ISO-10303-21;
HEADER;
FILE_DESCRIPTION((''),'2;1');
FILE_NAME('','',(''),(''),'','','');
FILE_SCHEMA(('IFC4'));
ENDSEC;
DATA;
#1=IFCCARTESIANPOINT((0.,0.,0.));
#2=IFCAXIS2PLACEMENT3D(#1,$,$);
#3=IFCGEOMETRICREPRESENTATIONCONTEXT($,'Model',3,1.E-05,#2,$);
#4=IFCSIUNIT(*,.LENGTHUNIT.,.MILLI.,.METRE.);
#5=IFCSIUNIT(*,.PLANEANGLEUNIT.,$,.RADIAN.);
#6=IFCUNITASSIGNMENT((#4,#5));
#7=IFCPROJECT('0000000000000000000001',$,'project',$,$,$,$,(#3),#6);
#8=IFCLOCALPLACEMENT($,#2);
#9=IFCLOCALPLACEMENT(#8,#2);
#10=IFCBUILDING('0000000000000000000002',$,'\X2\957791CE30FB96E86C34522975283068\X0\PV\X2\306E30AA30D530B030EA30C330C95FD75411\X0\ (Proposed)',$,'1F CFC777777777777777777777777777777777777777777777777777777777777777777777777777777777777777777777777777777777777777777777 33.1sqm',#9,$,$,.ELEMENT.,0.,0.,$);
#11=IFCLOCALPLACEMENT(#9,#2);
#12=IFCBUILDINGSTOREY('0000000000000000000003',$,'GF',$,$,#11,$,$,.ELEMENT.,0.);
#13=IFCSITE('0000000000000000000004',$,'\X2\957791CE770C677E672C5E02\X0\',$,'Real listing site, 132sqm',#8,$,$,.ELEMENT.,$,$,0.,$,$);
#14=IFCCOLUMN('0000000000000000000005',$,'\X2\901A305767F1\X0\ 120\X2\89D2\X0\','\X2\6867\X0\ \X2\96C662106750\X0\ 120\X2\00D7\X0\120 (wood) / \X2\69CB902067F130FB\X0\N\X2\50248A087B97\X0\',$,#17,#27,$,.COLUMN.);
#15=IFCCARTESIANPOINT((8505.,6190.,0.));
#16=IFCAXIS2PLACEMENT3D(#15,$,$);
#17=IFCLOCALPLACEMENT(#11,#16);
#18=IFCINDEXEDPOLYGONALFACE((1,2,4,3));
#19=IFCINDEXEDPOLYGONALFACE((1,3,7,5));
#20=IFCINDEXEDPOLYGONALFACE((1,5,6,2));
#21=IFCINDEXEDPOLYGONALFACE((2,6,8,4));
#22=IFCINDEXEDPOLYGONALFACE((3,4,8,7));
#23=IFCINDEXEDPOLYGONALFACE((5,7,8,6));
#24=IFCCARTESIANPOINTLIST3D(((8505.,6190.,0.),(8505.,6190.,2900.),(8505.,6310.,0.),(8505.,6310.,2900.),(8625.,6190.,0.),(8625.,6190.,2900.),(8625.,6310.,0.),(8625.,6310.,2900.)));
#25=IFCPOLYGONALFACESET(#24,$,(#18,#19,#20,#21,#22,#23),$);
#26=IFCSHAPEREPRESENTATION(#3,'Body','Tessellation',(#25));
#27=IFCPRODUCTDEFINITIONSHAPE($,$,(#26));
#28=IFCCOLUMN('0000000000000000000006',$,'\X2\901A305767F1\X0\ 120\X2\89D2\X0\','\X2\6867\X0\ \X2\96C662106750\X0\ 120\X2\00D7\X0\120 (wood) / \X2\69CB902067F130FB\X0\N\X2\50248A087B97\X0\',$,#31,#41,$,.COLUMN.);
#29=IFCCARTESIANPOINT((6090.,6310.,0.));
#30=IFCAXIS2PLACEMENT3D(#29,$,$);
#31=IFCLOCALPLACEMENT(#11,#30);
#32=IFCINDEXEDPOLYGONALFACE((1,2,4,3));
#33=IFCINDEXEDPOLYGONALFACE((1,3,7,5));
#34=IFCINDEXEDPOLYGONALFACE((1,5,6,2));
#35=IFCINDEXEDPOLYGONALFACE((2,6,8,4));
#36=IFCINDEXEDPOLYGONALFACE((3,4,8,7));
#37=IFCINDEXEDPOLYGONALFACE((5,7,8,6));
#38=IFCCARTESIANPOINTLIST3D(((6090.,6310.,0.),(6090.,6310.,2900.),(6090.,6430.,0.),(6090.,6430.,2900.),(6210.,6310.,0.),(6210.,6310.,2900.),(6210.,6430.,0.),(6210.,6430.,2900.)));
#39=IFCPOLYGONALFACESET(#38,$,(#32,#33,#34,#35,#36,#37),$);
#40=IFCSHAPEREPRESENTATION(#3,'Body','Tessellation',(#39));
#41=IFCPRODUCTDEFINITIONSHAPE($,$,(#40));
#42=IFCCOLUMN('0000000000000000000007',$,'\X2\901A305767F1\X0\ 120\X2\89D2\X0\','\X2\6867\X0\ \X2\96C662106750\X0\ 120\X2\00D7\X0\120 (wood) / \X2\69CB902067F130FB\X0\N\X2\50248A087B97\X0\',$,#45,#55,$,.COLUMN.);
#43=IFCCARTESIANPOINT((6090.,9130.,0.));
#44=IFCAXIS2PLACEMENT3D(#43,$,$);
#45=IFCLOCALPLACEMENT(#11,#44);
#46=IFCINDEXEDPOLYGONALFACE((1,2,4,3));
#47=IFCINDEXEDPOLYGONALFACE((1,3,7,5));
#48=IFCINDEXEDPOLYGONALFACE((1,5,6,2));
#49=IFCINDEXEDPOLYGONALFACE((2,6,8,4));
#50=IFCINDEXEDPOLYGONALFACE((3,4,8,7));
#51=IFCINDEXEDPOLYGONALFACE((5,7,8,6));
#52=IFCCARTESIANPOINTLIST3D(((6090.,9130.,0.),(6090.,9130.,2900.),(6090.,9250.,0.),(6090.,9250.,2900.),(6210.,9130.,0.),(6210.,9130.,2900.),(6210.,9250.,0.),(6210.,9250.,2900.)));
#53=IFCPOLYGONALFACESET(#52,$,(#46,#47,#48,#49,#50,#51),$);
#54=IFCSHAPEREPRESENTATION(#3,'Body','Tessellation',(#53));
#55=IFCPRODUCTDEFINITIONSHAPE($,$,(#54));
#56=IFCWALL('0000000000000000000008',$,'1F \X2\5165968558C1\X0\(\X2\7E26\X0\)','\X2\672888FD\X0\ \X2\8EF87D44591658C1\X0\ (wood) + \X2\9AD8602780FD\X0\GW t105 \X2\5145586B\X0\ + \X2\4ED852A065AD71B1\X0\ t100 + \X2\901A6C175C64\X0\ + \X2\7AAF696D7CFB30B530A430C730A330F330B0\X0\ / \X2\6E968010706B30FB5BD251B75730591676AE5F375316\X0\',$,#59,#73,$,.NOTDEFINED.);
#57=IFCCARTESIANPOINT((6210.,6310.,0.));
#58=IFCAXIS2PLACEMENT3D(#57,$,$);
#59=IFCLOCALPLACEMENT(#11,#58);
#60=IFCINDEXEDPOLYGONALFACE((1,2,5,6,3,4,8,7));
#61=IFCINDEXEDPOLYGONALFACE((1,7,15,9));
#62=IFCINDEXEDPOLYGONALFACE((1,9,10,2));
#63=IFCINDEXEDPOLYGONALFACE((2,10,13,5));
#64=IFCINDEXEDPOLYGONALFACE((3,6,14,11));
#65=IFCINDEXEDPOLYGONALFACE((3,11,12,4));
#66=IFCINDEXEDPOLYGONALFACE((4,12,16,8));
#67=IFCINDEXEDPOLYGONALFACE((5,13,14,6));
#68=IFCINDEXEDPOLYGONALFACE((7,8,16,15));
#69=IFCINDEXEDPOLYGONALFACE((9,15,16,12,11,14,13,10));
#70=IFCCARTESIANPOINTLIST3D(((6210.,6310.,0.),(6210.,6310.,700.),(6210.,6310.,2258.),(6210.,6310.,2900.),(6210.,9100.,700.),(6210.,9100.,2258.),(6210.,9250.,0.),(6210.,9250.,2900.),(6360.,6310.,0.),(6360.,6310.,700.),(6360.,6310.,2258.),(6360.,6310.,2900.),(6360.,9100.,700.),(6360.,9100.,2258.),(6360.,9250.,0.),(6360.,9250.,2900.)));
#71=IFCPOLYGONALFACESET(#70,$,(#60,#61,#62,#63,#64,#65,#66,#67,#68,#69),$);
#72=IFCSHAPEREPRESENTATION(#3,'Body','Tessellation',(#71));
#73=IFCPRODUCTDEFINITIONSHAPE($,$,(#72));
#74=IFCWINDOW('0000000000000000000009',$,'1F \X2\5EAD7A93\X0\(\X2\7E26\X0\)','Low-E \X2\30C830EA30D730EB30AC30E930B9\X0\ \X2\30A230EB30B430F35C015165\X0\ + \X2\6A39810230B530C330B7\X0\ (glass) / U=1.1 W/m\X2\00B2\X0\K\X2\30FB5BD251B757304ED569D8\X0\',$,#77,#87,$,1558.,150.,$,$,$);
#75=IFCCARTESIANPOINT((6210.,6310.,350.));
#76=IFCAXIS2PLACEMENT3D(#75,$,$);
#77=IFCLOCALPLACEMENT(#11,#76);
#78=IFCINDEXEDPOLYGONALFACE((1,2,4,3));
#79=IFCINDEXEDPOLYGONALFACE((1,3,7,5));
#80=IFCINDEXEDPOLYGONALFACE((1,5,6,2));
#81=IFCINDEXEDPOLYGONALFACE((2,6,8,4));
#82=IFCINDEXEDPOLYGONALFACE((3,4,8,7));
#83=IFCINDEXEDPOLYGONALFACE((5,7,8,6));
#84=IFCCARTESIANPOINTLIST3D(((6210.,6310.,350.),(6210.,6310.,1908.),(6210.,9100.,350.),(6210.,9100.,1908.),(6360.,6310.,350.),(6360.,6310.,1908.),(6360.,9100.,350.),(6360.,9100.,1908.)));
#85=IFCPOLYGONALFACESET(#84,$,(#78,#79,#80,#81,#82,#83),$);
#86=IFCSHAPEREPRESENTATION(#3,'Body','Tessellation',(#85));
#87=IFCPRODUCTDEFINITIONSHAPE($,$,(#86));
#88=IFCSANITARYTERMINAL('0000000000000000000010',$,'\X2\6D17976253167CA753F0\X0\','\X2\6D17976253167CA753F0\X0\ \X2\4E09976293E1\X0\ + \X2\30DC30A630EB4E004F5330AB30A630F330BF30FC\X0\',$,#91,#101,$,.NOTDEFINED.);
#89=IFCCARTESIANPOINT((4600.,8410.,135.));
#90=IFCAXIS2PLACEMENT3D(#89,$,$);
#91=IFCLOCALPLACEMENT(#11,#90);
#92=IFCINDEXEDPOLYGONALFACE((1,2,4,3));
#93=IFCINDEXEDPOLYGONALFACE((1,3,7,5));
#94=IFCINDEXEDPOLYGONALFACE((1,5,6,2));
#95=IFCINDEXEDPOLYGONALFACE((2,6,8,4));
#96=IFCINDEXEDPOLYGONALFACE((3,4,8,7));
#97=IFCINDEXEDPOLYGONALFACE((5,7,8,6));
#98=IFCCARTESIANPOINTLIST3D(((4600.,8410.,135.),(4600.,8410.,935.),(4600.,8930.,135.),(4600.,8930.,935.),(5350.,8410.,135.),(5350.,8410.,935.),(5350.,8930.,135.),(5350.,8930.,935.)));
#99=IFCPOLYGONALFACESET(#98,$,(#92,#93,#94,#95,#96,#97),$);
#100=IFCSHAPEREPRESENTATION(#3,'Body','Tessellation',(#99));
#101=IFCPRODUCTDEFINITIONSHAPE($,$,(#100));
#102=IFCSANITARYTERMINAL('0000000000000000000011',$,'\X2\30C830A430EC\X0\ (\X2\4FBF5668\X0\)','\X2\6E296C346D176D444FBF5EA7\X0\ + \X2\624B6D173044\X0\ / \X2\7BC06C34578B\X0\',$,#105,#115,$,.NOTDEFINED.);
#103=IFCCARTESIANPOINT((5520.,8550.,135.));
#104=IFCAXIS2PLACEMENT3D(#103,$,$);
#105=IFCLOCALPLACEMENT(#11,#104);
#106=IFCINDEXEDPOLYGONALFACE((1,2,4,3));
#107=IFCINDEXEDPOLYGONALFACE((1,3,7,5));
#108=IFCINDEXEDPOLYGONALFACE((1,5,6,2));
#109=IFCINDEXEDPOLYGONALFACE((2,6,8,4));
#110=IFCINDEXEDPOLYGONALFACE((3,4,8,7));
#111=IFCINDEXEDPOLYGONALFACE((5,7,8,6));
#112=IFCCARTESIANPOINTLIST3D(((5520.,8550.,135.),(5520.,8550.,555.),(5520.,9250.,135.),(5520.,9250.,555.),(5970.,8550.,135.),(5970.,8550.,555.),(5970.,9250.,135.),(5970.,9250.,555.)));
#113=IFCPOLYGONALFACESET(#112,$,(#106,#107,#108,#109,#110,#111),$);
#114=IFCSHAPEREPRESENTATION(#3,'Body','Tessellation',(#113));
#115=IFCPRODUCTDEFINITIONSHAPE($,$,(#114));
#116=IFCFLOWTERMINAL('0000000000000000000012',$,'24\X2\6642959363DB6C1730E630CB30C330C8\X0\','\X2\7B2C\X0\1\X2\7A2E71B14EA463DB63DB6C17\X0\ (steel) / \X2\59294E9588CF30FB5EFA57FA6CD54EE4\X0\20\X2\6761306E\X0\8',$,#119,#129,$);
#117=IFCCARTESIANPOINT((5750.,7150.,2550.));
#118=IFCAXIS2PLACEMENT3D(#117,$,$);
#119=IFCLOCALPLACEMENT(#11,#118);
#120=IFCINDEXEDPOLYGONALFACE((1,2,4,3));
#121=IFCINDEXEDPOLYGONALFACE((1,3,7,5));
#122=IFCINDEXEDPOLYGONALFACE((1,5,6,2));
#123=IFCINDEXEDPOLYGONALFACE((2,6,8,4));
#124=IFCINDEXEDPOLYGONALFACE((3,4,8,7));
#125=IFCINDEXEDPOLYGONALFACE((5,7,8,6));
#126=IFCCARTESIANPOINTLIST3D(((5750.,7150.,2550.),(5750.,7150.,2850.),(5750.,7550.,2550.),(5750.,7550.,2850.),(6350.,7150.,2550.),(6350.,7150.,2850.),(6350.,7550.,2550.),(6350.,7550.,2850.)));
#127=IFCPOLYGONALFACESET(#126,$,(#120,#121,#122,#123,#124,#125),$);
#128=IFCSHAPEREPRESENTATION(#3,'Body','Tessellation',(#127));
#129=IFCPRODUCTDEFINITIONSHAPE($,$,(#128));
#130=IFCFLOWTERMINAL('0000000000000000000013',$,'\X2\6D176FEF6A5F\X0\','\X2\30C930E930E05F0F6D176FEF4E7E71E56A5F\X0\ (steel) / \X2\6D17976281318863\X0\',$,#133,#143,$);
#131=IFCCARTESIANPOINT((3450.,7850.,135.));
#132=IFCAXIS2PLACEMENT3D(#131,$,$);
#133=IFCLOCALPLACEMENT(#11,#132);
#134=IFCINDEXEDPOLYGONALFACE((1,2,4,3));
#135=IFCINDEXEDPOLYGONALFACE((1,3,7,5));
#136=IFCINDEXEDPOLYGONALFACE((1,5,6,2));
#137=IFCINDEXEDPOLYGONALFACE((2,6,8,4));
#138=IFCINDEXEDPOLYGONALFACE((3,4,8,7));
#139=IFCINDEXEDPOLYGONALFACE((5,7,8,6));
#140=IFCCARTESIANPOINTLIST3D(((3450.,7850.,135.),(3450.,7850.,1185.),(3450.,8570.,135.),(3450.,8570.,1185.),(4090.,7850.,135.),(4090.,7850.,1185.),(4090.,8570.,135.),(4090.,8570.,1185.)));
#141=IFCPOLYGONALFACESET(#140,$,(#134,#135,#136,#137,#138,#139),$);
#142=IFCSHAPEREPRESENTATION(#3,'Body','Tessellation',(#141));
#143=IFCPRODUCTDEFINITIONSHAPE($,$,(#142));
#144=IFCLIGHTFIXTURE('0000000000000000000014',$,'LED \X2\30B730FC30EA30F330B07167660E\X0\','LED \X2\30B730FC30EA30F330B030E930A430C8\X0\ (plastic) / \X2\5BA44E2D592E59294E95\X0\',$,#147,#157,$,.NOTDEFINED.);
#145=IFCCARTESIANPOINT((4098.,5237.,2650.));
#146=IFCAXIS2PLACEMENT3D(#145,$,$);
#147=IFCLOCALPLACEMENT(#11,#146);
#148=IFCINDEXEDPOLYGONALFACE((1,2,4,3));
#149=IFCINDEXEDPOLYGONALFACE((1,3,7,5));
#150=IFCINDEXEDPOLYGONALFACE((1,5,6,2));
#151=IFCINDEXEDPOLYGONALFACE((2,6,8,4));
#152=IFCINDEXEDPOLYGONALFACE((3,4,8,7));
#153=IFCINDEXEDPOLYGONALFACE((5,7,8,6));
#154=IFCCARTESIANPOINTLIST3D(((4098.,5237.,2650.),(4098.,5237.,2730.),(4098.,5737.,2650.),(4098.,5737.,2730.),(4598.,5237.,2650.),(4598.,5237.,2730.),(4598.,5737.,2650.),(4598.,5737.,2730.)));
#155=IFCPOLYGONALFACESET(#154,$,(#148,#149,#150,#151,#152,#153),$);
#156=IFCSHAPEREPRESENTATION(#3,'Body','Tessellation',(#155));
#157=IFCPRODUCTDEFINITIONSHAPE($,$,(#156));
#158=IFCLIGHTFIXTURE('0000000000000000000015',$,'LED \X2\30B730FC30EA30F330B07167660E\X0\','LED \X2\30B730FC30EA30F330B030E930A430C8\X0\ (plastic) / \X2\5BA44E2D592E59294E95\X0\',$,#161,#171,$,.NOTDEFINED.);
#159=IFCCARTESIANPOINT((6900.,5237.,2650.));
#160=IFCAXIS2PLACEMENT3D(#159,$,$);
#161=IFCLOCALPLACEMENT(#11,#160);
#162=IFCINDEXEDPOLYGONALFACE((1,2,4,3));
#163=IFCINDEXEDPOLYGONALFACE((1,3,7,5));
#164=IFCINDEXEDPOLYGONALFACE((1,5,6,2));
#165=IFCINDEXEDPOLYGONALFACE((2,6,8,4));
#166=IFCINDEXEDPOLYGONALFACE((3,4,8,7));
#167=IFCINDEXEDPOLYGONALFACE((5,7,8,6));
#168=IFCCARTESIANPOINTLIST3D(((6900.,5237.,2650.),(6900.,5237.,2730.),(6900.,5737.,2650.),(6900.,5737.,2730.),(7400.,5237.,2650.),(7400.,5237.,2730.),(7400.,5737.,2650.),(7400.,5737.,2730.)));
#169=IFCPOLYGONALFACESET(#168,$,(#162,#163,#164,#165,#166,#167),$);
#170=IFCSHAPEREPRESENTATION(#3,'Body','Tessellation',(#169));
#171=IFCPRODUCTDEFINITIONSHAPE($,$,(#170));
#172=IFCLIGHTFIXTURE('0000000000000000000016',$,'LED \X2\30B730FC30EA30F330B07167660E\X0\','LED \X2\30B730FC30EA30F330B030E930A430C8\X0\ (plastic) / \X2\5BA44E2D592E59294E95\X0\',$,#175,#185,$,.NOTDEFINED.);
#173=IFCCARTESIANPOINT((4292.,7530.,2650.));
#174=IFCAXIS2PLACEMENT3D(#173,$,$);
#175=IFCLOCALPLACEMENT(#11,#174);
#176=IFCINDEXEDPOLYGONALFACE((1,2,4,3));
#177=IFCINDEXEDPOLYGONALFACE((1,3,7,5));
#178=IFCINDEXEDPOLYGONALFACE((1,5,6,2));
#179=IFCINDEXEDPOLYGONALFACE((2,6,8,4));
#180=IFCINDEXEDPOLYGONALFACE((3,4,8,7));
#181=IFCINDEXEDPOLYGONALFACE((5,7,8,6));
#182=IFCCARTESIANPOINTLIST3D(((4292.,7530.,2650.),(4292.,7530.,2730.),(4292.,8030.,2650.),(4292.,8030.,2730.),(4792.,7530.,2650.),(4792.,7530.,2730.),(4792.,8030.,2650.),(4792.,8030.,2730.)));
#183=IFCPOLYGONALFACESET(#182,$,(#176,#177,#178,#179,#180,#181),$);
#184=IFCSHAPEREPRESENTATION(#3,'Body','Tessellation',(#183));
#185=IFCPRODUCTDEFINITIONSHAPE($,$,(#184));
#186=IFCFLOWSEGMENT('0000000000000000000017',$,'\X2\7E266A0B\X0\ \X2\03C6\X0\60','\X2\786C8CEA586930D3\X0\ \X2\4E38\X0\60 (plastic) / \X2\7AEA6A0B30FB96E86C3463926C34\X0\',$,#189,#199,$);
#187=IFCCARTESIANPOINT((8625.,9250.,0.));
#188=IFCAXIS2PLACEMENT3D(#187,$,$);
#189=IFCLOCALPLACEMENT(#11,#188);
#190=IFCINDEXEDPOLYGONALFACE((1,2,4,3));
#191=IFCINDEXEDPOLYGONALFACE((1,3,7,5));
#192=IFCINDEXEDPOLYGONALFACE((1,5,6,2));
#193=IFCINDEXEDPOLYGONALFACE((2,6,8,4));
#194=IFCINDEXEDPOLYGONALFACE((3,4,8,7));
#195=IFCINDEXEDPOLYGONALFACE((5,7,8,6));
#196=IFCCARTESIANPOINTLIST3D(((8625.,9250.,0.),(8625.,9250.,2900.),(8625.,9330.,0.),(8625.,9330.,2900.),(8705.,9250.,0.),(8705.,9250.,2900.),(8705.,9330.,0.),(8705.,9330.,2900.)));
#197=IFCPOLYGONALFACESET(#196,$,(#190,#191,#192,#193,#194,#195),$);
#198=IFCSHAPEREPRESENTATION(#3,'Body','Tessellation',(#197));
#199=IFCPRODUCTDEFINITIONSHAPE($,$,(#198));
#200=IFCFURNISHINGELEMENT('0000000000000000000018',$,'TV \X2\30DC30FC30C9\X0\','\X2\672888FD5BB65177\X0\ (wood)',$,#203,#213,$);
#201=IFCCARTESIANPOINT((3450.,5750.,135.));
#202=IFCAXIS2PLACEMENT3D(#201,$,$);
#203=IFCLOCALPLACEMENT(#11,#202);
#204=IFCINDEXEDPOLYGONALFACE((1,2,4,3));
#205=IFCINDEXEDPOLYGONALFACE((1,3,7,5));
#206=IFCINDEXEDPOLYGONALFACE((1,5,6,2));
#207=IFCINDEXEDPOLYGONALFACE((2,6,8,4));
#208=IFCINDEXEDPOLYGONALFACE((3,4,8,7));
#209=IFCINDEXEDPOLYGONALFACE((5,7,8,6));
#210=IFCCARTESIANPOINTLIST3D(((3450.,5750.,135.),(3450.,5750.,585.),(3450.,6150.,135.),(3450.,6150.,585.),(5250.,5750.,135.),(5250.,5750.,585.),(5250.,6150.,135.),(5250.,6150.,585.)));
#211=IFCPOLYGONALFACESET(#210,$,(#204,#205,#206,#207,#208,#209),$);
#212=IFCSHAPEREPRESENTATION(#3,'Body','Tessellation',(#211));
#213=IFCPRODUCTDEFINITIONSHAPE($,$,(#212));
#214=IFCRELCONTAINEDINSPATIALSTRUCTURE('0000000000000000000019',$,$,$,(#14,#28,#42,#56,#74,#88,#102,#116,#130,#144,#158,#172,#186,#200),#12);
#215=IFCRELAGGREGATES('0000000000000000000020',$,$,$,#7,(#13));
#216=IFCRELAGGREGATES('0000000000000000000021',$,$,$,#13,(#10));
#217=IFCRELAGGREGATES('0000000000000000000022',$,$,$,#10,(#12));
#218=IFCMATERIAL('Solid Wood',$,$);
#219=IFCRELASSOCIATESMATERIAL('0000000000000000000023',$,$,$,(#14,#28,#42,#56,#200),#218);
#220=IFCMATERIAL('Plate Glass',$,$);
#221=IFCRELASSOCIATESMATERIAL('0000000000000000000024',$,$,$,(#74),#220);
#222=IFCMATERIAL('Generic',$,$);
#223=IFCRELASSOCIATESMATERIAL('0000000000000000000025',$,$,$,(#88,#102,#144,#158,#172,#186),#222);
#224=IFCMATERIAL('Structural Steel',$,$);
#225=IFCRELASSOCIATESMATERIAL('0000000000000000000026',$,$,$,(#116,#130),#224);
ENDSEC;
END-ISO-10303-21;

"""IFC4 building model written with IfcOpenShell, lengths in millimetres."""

from ifc_helpers import new_model, si_unit, frame, frame_2d, origin, place, context, project, spatial, rectangle, extrude, material, element, fill, save


model = new_model("IFC4")

# Units and contexts
model_context = context("Model", 3, precision=1e-05, world=origin())
ifc_project = project(units=[si_unit("LENGTHUNIT", "METRE", prefix="MILLI"), si_unit("PLANEANGLEUNIT", "RADIAN")], contexts=[model_context])

# Site, building, storey
site_placement = place(None, origin())
site = spatial("IfcSite", under=ifc_project, at=site_placement, Name="長野県松本市", ObjectType="Real listing site, 132sqm", CompositionType="ELEMENT", RefElevation=0.0)
building_placement = place(site_placement, origin())
building = spatial("IfcBuilding", under=site, at=building_placement, Name="長野・雨水利用とPVのオフグリッド志向 (Proposed)", ObjectType="1F CFC777777777777777777777777777777777777777777777777777777777777777777777777777777777777777777777777777777777777777777777 33.1sqm", CompositionType="ELEMENT", ElevationOfRefHeight=0.0, ElevationOfTerrain=0.0)
storey_placement = place(building_placement, origin())
storey = spatial("IfcBuildingStorey", under=building, at=storey_placement, Name="GF", CompositionType="ELEMENT", Elevation=0.0)

# Columns
ifc_material_1 = material(Name="Solid Wood")
column_1_placement = place(storey_placement, frame((8505.0, 6190.0, 0.0)))
element("IfcColumn", 1, at=column_1_placement, inside=storey, material=ifc_material_1, Name="通し柱 120角", Description="桧 集成材 120×120 (wood) / 構造柱・N値計算", PredefinedType="COLUMN", context=model_context, shape_type="SweptSolid", body=[
    extrude(rectangle(XDim=120.0, YDim=120.0, at=frame_2d((60.0, 60.0))), frame((8505.0, 6190.0, 0.0)), (0.0, 0.0, 1.0), 2900.0),
])
column_2_placement = place(storey_placement, frame((6090.0, 6310.0, 0.0)))
element("IfcColumn", 2, at=column_2_placement, inside=storey, material=ifc_material_1, Name="通し柱 120角", Description="桧 集成材 120×120 (wood) / 構造柱・N値計算", PredefinedType="COLUMN", context=model_context, shape_type="SweptSolid", body=[
    extrude(rectangle(XDim=120.0, YDim=120.0, at=frame_2d((60.0, 60.0))), frame((6090.0, 6310.0, 0.0)), (0.0, 0.0, 1.0), 2900.0),
])
column_3_placement = place(storey_placement, frame((6090.0, 9130.0, 0.0)))
element("IfcColumn", 3, at=column_3_placement, inside=storey, material=ifc_material_1, Name="通し柱 120角", Description="桧 集成材 120×120 (wood) / 構造柱・N値計算", PredefinedType="COLUMN", context=model_context, shape_type="SweptSolid", body=[
    extrude(rectangle(XDim=120.0, YDim=120.0, at=frame_2d((60.0, 60.0))), frame((6090.0, 9130.0, 0.0)), (0.0, 0.0, 1.0), 2900.0),
])

# Wall, opening, window
wall_1_placement = place(storey_placement, frame((6210.0, 6310.0, 0.0)))
wall_1 = element("IfcWall", 4, at=wall_1_placement, inside=storey, material=ifc_material_1, Name="1F 入隅壁(縦)", Description="木製 軸組外壁 (wood) + 高性能GW t105 充填 + 付加断熱 t100 + 通気層 + 窯業系サイディング / 準耐火・寒冷地外皮強化", PredefinedType="NOTDEFINED", context=model_context, shape_type="SweptSolid", body=[
    extrude(rectangle(XDim=150.0, YDim=2940.0, at=frame_2d((75.0, 1470.0))), frame((6210.0, 6310.0, 0.0)), (0.0, 0.0, 1.0), 2900.0),
])
opening_placement = place(storey_placement, frame((6210.0, 6310.0, 350.0)))
opening = element("IfcOpeningElement", 5, at=opening_placement, cuts=wall_1, PredefinedType="NOTDEFINED", context=model_context, shape_type="SweptSolid", body=[
    extrude(rectangle(XDim=150.0, YDim=2790.0, at=frame_2d((75.0, 1395.0))), frame((6210.0, 6310.0, 350.0)), (0.0, 0.0, 1.0), 1558.0),
])
ifc_material_2 = material(Name="Plate Glass")
window_placement = place(storey_placement, frame((6210.0, 6310.0, 350.0)))
window = element("IfcWindow", 6, at=window_placement, inside=storey, material=ifc_material_2, Name="1F 庭窓(縦)", Description="Low-E トリプルガラス アルゴン封入 + 樹脂サッシ (glass) / U=1.1 W/m²K・寒冷地仕様", OverallHeight=1558.0, OverallWidth=150.0, context=model_context, shape_type="SweptSolid", body=[
    extrude(rectangle(XDim=150.0, YDim=2790.0, at=frame_2d((75.0, 1395.0))), frame((6210.0, 6310.0, 350.0)), (0.0, 0.0, 1.0), 1558.0),
])
fill(opening, window)

# Sanitary terminals
ifc_material_3 = material(Name="Generic")
sanitary_terminal_1_placement = place(storey_placement, frame((4600.0, 8410.0, 135.0)))
element("IfcSanitaryTerminal", 7, at=sanitary_terminal_1_placement, inside=storey, material=ifc_material_3, Name="洗面化粧台", Description="洗面化粧台 三面鏡 + ボウル一体カウンター", PredefinedType="NOTDEFINED", context=model_context, shape_type="SweptSolid", body=[
    extrude(rectangle(XDim=750.0, YDim=520.0, at=frame_2d((375.0, 260.0))), frame((4600.0, 8410.0, 135.0)), (0.0, 0.0, 1.0), 800.0),
])
sanitary_terminal_2_placement = place(storey_placement, frame((5520.0, 8550.0, 135.0)))
element("IfcSanitaryTerminal", 8, at=sanitary_terminal_2_placement, inside=storey, material=ifc_material_3, Name="トイレ (便器)", Description="温水洗浄便座 + 手洗い / 節水型", PredefinedType="NOTDEFINED", context=model_context, shape_type="SweptSolid", body=[
    extrude(rectangle(XDim=450.0, YDim=700.0, at=frame_2d((225.0, 350.0))), frame((5520.0, 8550.0, 135.0)), (0.0, 0.0, 1.0), 420.0),
])

# Flow terminals
ifc_material_4 = material(Name="Structural Steel")
flow_terminal_1_placement = place(storey_placement, frame((5750.0, 7150.0, 2550.0)))
element("IfcFlowTerminal", 9, at=flow_terminal_1_placement, inside=storey, material=ifc_material_4, Name="24時間換気ユニット", Description="第1種熱交換換気 (steel) / 天井裏・建基法令20条の8", context=model_context, shape_type="SweptSolid", body=[
    extrude(rectangle(XDim=600.0, YDim=400.0, at=frame_2d((300.0, 200.0))), frame((5750.0, 7150.0, 2550.0)), (0.0, 0.0, 1.0), 300.0),
])
flow_terminal_2_placement = place(storey_placement, frame((3450.0, 7850.0, 135.0)))
element("IfcFlowTerminal", 10, at=flow_terminal_2_placement, inside=storey, material=ifc_material_4, Name="洗濯機", Description="ドラム式洗濯乾燥機 (steel) / 洗面脱衣", context=model_context, shape_type="SweptSolid", body=[
    extrude(rectangle(XDim=640.0, YDim=720.0, at=frame_2d((320.0, 360.0))), frame((3450.0, 7850.0, 135.0)), (0.0, 0.0, 1.0), 1050.0),
])

# Light fixtures
light_fixture_1_placement = place(storey_placement, frame((4098.0, 5237.0, 2650.0)))
element("IfcLightFixture", 11, at=light_fixture_1_placement, inside=storey, material=ifc_material_3, Name="LED シーリング照明", Description="LED シーリングライト (plastic) / 室中央天井", PredefinedType="NOTDEFINED", context=model_context, shape_type="SweptSolid", body=[
    extrude(rectangle(XDim=500.0, YDim=500.0, at=frame_2d((250.0, 250.0))), frame((4098.0, 5237.0, 2650.0)), (0.0, 0.0, 1.0), 80.0),
])
light_fixture_2_placement = place(storey_placement, frame((6900.0, 5237.0, 2650.0)))
element("IfcLightFixture", 12, at=light_fixture_2_placement, inside=storey, material=ifc_material_3, Name="LED シーリング照明", Description="LED シーリングライト (plastic) / 室中央天井", PredefinedType="NOTDEFINED", context=model_context, shape_type="SweptSolid", body=[
    extrude(rectangle(XDim=500.0, YDim=500.0, at=frame_2d((250.0, 250.0))), frame((6900.0, 5237.0, 2650.0)), (0.0, 0.0, 1.0), 80.0),
])
light_fixture_3_placement = place(storey_placement, frame((4292.0, 7530.0, 2650.0)))
element("IfcLightFixture", 13, at=light_fixture_3_placement, inside=storey, material=ifc_material_3, Name="LED シーリング照明", Description="LED シーリングライト (plastic) / 室中央天井", PredefinedType="NOTDEFINED", context=model_context, shape_type="SweptSolid", body=[
    extrude(rectangle(XDim=500.0, YDim=500.0, at=frame_2d((250.0, 250.0))), frame((4292.0, 7530.0, 2650.0)), (0.0, 0.0, 1.0), 80.0),
])

# Flow segment
flow_segment_placement = place(storey_placement, frame((8625.0, 9250.0, 0.0)))
element("IfcFlowSegment", 14, at=flow_segment_placement, inside=storey, material=ifc_material_3, Name="縦樋 φ60", Description="硬質塩ビ 丸60 (plastic) / 竪樋・雨水排水", context=model_context, shape_type="SweptSolid", body=[
    extrude(rectangle(XDim=80.0, YDim=80.0, at=frame_2d((40.0, 40.0))), frame((8625.0, 9250.0, 0.0)), (0.0, 0.0, 1.0), 2900.0),
])

# Furnishing element
furnishing_placement = place(storey_placement, frame((3450.0, 5750.0, 135.0)))
element("IfcFurnishingElement", 15, at=furnishing_placement, inside=storey, material=ifc_material_1, Name="TV ボード", Description="木製家具 (wood)", context=model_context, shape_type="SweptSolid", body=[
    extrude(rectangle(XDim=1800.0, YDim=400.0, at=frame_2d((900.0, 200.0))), frame((3450.0, 5750.0, 135.0)), (0.0, 0.0, 1.0), 450.0),
])

save(model, "model.ifc")
